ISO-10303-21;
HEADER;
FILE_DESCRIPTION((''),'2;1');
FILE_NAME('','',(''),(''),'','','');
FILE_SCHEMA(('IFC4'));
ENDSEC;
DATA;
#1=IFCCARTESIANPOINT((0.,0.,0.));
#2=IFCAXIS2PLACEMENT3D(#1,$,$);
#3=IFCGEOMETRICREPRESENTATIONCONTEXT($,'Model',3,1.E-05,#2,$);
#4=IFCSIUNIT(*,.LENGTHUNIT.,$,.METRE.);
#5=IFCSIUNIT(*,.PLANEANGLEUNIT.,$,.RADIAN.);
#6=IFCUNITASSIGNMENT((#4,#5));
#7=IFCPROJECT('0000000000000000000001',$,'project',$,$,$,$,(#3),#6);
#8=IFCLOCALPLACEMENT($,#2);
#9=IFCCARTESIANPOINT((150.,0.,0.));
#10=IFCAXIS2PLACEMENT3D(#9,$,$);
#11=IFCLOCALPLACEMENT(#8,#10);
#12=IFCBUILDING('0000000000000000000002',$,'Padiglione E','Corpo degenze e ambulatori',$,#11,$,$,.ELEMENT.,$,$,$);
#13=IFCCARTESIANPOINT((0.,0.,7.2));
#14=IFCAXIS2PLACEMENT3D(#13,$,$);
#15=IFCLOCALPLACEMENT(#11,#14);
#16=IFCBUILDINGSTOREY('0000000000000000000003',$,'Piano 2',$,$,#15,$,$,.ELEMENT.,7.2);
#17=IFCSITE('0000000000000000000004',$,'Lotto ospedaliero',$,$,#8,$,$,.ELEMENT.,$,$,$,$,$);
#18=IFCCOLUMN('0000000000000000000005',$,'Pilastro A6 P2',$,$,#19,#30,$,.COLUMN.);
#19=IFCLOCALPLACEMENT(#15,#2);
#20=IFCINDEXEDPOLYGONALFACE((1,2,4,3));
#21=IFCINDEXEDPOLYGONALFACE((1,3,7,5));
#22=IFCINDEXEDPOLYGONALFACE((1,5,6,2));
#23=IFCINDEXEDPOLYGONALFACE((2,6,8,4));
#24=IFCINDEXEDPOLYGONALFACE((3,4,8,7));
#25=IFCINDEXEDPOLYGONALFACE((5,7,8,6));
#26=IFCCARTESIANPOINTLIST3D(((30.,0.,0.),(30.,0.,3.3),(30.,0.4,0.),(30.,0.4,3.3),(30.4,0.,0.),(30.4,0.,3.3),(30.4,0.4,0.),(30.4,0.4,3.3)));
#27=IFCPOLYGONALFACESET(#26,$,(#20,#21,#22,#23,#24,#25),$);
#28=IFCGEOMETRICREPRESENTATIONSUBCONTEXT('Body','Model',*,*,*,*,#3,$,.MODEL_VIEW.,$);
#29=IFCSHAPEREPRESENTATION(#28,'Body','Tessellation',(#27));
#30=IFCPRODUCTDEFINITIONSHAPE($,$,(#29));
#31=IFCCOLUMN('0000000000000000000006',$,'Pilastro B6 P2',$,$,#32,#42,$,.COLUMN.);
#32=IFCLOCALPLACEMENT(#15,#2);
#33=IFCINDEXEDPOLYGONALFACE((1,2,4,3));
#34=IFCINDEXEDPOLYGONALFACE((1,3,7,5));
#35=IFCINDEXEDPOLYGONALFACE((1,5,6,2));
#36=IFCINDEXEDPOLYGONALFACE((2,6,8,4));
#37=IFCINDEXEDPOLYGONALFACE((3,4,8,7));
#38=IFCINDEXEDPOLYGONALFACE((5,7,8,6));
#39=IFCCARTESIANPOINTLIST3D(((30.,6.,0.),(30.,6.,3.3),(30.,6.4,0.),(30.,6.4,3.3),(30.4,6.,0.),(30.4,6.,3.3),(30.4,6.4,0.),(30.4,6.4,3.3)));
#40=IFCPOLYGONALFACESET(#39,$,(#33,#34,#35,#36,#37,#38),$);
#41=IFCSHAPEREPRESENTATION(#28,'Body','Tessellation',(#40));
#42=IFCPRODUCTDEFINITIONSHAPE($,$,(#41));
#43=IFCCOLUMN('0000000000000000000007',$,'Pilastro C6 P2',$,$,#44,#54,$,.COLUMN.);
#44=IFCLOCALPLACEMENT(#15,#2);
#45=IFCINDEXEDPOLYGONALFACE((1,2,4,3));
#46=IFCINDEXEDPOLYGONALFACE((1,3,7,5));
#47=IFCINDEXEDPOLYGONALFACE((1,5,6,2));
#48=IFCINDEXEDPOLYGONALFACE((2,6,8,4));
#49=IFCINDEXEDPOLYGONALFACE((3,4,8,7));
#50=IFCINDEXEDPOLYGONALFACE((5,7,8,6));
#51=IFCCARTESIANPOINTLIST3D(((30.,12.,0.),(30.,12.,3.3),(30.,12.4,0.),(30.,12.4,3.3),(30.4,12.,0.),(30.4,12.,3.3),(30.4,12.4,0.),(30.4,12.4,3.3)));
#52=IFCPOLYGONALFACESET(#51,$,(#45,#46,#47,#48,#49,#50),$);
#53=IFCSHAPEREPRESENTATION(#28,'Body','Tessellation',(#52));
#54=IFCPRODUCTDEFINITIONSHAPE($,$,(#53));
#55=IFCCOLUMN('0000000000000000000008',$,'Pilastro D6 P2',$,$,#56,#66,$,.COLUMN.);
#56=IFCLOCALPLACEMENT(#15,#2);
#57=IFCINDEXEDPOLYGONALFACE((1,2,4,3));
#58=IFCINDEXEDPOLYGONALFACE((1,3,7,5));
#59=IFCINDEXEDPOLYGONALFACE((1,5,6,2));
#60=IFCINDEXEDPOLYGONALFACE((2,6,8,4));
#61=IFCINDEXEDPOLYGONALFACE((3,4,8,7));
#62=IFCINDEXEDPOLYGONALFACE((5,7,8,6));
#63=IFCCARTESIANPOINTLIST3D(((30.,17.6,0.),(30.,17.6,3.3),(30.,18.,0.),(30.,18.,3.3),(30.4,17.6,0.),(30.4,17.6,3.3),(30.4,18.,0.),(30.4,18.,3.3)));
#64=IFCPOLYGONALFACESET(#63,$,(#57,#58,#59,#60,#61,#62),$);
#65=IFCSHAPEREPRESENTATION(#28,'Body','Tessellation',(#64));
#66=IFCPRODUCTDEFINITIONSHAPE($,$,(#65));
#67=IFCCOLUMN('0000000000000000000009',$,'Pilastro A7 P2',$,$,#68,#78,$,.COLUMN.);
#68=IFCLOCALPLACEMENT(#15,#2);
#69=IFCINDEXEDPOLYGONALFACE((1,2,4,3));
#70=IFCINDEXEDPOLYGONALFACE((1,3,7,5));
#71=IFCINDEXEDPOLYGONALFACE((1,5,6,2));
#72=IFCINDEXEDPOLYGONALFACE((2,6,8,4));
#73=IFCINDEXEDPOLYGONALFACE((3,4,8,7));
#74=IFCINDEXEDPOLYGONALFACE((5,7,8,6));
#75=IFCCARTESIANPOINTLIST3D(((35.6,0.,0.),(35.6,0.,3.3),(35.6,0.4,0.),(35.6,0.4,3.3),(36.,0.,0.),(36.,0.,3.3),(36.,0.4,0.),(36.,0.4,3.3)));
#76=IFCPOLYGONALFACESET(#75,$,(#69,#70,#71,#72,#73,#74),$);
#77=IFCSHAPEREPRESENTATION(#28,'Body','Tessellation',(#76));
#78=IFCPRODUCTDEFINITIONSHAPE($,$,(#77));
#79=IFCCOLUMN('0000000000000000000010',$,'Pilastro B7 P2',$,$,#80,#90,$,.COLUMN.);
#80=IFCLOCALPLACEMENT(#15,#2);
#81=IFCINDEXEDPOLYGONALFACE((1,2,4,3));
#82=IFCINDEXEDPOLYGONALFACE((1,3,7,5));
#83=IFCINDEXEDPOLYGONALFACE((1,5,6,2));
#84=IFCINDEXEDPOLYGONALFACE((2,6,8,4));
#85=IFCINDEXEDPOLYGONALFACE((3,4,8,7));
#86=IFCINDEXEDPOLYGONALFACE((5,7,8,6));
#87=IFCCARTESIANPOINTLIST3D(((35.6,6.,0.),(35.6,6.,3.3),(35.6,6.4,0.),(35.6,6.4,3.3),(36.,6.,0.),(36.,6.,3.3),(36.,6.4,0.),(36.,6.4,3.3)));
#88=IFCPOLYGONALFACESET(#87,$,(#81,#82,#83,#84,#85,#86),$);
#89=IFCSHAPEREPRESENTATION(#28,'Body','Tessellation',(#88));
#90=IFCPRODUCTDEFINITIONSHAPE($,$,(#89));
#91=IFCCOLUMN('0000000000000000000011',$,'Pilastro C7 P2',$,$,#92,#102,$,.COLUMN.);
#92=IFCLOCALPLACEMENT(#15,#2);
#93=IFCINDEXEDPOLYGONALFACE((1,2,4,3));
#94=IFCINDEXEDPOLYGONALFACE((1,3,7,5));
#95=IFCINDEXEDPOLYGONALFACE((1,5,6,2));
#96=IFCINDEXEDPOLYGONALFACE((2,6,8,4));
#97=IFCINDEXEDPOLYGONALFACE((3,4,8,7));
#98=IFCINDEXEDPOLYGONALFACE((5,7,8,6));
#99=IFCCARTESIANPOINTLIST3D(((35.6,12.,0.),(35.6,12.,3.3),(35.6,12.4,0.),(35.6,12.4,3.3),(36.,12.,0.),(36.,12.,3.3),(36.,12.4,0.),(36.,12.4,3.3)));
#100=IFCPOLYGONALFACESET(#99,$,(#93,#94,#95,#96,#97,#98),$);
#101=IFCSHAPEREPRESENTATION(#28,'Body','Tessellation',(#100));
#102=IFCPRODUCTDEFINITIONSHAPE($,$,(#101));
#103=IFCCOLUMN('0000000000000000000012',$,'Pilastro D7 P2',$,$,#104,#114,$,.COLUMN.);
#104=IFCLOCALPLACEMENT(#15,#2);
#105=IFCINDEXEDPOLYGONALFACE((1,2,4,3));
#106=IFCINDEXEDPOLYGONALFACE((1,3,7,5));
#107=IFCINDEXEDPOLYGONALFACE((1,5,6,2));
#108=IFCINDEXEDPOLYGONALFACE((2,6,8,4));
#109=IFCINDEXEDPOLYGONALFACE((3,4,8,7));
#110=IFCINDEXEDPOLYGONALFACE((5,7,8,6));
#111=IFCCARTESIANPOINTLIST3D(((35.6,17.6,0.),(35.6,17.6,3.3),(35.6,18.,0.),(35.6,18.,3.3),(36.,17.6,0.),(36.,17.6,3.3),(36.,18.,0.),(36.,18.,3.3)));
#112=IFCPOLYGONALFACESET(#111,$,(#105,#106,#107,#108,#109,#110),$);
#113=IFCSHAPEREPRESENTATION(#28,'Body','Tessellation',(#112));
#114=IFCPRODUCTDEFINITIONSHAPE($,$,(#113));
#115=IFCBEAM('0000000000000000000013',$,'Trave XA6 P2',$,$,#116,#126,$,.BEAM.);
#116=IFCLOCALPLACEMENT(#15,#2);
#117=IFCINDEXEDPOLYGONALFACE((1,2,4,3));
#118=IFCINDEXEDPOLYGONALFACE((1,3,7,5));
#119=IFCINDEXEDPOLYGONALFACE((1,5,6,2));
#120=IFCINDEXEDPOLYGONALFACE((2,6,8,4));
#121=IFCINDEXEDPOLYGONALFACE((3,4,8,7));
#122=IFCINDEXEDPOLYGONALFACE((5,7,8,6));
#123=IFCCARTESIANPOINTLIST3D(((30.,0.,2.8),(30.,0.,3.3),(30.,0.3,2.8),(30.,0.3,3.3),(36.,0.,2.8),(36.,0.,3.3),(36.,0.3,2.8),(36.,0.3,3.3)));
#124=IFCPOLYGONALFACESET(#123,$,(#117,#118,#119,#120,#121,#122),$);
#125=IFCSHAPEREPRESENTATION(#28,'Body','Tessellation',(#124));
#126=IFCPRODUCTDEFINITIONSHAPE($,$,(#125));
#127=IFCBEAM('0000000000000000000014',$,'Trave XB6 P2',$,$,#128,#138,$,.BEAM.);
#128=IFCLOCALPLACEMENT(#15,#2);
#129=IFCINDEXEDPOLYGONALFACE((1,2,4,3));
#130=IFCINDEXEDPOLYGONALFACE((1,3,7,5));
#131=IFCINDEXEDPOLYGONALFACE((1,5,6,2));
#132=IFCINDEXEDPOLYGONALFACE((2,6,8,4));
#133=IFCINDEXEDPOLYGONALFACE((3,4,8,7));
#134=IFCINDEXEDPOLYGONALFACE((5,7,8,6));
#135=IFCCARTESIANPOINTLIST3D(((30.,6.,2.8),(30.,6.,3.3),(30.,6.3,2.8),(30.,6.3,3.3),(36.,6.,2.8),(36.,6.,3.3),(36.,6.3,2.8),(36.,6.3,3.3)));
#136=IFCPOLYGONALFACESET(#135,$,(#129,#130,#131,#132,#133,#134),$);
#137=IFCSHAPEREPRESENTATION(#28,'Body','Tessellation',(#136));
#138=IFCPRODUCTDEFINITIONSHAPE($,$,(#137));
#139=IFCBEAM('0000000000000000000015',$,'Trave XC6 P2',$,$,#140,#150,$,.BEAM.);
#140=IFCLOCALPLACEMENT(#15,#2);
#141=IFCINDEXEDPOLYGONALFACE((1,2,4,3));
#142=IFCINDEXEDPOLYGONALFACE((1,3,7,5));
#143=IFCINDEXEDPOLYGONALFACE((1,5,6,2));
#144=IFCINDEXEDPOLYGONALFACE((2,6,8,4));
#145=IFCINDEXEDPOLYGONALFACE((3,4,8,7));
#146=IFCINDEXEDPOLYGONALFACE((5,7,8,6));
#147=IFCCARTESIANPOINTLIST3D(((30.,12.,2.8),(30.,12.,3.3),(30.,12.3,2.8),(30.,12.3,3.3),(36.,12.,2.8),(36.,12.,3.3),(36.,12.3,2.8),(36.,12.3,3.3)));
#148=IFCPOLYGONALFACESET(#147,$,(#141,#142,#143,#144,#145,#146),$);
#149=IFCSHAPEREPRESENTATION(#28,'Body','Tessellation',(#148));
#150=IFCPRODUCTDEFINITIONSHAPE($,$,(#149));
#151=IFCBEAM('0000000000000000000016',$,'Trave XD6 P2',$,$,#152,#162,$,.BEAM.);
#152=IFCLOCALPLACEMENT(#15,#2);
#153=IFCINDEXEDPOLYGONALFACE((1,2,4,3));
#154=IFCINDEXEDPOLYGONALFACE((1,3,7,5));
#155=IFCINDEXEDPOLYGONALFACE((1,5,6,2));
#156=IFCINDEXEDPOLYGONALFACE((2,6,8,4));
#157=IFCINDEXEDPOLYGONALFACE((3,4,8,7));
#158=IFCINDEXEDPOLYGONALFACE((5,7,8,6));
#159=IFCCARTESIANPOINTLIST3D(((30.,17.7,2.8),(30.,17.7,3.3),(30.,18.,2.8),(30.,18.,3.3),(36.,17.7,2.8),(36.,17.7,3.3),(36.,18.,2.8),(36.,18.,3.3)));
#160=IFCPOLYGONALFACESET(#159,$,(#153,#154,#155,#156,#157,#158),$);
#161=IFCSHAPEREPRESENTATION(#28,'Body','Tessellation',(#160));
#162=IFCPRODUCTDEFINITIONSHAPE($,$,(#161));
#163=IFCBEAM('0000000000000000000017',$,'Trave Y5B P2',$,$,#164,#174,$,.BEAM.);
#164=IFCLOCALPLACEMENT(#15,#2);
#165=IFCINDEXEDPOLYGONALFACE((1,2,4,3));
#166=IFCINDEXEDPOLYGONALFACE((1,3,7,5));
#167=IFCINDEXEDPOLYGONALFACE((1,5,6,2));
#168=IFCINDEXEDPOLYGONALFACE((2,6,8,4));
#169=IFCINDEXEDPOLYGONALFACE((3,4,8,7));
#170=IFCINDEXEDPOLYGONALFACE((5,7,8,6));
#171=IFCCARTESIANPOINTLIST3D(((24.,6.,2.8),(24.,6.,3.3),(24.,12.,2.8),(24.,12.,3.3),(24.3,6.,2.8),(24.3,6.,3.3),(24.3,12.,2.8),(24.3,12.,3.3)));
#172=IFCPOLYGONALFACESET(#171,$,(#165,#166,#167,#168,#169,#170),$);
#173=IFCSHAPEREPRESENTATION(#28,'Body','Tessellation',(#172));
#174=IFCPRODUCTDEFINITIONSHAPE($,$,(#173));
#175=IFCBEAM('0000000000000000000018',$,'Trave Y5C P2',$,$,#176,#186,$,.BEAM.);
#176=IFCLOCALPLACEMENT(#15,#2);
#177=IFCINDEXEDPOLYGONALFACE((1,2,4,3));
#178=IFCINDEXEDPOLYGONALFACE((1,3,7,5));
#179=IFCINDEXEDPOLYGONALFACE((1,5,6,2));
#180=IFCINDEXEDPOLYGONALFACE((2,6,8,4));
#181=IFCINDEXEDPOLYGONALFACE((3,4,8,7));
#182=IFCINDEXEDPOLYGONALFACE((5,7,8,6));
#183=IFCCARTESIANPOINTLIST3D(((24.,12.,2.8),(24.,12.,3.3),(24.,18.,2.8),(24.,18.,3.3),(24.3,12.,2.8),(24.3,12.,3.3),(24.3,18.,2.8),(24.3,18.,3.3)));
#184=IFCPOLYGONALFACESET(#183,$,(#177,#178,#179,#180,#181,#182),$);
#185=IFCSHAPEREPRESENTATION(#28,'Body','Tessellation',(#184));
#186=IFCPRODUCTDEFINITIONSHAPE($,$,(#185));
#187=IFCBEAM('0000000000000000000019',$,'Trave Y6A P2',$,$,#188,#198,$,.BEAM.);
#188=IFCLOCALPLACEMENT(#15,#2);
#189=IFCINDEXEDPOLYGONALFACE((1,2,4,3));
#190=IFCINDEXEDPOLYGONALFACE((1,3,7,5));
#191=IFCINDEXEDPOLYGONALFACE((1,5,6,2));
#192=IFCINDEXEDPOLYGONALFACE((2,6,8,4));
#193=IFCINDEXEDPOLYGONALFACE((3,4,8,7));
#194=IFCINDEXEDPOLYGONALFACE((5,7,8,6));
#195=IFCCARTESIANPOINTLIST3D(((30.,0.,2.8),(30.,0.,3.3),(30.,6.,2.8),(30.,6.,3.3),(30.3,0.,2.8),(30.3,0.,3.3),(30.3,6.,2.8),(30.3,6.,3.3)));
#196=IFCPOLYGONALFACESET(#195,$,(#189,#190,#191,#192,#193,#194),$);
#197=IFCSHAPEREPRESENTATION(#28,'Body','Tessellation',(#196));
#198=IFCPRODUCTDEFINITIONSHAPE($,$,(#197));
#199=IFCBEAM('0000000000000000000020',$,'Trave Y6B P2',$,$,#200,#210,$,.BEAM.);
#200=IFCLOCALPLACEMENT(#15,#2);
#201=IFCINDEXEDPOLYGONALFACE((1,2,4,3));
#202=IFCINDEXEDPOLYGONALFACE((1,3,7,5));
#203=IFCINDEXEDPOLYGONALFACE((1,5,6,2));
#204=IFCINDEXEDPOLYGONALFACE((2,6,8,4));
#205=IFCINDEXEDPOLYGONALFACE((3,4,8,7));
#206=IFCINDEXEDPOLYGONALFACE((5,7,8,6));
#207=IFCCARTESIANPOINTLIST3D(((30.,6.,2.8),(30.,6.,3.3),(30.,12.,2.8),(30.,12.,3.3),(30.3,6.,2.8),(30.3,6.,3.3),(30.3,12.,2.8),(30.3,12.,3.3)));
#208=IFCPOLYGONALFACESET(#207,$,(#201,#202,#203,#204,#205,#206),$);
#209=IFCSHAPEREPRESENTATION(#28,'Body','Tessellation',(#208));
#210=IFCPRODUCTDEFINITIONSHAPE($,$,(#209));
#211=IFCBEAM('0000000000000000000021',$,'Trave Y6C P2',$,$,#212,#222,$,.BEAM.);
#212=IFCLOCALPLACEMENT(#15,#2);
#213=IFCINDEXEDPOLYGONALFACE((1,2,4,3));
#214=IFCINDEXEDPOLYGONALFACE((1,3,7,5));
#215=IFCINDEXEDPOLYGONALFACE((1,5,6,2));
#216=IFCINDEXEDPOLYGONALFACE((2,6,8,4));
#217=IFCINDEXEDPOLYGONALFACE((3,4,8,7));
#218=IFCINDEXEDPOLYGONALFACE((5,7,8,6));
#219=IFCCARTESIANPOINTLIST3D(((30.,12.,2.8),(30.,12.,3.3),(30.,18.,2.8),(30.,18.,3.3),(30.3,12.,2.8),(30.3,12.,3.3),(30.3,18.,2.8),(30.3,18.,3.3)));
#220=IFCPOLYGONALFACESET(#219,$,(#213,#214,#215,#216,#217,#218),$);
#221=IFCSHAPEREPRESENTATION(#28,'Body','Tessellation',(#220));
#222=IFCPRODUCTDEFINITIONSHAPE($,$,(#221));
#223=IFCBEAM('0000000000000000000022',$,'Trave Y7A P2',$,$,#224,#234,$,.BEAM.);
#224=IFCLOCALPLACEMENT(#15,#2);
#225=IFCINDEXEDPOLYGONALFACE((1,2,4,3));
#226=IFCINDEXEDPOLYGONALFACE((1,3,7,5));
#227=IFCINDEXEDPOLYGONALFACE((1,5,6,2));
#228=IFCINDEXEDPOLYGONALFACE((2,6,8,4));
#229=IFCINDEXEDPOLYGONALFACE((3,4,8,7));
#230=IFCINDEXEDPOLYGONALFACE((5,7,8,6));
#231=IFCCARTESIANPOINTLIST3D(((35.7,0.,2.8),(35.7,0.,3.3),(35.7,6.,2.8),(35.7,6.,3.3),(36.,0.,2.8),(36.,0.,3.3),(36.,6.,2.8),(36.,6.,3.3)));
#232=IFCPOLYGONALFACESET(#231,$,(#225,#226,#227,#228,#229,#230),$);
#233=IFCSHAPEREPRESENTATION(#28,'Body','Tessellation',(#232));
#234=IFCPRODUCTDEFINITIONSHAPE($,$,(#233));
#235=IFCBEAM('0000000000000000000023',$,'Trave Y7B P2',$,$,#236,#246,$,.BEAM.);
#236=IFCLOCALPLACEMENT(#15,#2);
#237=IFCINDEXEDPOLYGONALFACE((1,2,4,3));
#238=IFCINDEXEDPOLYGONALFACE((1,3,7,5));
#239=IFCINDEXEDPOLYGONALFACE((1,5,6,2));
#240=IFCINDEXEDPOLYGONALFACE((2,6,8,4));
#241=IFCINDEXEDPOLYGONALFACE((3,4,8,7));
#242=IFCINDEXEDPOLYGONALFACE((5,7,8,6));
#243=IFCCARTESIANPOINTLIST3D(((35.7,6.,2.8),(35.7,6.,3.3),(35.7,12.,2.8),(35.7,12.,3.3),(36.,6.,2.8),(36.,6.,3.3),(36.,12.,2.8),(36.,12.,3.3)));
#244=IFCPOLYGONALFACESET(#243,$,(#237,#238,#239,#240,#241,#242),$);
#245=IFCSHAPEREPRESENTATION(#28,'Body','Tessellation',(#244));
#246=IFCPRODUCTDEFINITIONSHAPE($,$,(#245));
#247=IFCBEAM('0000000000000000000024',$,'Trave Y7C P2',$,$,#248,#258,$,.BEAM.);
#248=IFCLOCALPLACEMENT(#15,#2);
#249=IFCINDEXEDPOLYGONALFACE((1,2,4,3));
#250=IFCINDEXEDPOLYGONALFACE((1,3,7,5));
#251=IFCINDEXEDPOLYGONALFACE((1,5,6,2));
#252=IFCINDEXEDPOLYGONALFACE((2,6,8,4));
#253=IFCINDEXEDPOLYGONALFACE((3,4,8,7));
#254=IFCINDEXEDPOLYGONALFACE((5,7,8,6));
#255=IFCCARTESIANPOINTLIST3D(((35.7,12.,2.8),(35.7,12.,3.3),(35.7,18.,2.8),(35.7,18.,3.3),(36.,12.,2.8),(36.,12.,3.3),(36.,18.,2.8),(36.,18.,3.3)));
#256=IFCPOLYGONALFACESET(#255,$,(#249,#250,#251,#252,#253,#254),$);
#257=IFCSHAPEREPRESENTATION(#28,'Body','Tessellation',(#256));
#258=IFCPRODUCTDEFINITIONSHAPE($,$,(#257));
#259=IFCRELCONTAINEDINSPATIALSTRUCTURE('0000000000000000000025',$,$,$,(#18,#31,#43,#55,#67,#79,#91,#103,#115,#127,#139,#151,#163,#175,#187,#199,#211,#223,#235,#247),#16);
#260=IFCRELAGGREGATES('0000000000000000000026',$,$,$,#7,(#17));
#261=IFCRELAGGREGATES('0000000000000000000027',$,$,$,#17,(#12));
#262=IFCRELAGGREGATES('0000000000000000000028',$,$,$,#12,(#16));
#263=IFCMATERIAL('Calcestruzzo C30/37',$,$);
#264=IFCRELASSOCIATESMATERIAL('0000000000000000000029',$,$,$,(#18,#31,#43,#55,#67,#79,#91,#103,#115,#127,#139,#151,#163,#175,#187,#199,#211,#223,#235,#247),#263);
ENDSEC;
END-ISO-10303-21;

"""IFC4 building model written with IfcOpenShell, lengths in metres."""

from ifc_helpers import new_model, si_unit, frame, frame_2d, origin, place, context, subcontext, project, spatial, rectangle, extrude, material, element, save


model = new_model("IFC4")

# Units and contexts
model_context = context("Model", 3, precision=1e-05, world=origin())
body_context = subcontext(model_context, "Body", "Model", "MODEL_VIEW")
ifc_project = project(units=[si_unit("LENGTHUNIT", "METRE"), si_unit("PLANEANGLEUNIT", "RADIAN")], contexts=[model_context])

# Site, building, storey
site_placement = place(None, origin())
site = spatial("IfcSite", under=ifc_project, at=site_placement, Name="Lotto ospedaliero", CompositionType="ELEMENT")
building_placement = place(site_placement, frame((150.0, 0.0, 0.0)))
building = spatial("IfcBuilding", under=site, at=building_placement, Name="Padiglione E", Description="Corpo degenze e ambulatori", CompositionType="ELEMENT")
storey_placement = place(building_placement, frame((0.0, 0.0, 7.2)))
storey = spatial("IfcBuildingStorey", under=building, at=storey_placement, Name="Piano 2", CompositionType="ELEMENT", Elevation=7.2)

# Columns
ifc_material_1 = material(Name="Calcestruzzo C30/37")
for number, where, name in (
    (1, (30.0, 0.0, 0.0), "Pilastro A6 P2"),
    (2, (30.0, 6.0, 0.0), "Pilastro B6 P2"),
    (3, (30.0, 12.0, 0.0), "Pilastro C6 P2"),
    (4, (30.0, 17.6, 0.0), "Pilastro D6 P2"),
    (5, (35.6, 0.0, 0.0), "Pilastro A7 P2"),
    (6, (35.6, 6.0, 0.0), "Pilastro B7 P2"),
    (7, (35.6, 12.0, 0.0), "Pilastro C7 P2"),
    (8, (35.6, 17.6, 0.0), "Pilastro D7 P2"),
):
    element("IfcColumn", number, at=place(storey_placement, frame(where)), inside=storey, material=ifc_material_1, Name=name, PredefinedType="COLUMN", context=body_context, shape_type="SweptSolid", body=[
        extrude(rectangle(XDim=0.4, YDim=0.4, at=frame_2d((0.2, 0.2))), origin(), (0.0, 0.0, 1.0), 3.3),
    ])

# Beams
for number, where, name in (
    (9, (30.0, 0.0, 2.8), "Trave XA6 P2"),
    (10, (30.0, 6.0, 2.8), "Trave XB6 P2"),
    (11, (30.0, 12.0, 2.8), "Trave XC6 P2"),
    (12, (30.0, 17.7, 2.8), "Trave XD6 P2"),
):
    element("IfcBeam", number, at=place(storey_placement, frame(where)), inside=storey, material=ifc_material_1, Name=name, PredefinedType="BEAM", context=body_context, shape_type="SweptSolid", body=[
        extrude(rectangle(XDim=6.0, YDim=0.3, at=frame_2d((3.0, 0.15))), origin(), (0.0, 0.0, 1.0), 0.5),
    ])
for number, where, name in (
    (13, (24.0, 6.0, 2.8), "Trave Y5B P2"),
    (14, (24.0, 12.0, 2.8), "Trave Y5C P2"),
    (15, (30.0, 0.0, 2.8), "Trave Y6A P2"),
    (16, (30.0, 6.0, 2.8), "Trave Y6B P2"),
    (17, (30.0, 12.0, 2.8), "Trave Y6C P2"),
    (18, (35.7, 0.0, 2.8), "Trave Y7A P2"),
    (19, (35.7, 6.0, 2.8), "Trave Y7B P2"),
    (20, (35.7, 12.0, 2.8), "Trave Y7C P2"),
):
    element("IfcBeam", number, at=place(storey_placement, frame(where)), inside=storey, material=ifc_material_1, Name=name, PredefinedType="BEAM", context=body_context, shape_type="SweptSolid", body=[
        extrude(rectangle(XDim=0.3, YDim=6.0, at=frame_2d((0.15, 3.0))), origin(), (0.0, 0.0, 1.0), 0.5),
    ])

save(model, "model.ifc")
